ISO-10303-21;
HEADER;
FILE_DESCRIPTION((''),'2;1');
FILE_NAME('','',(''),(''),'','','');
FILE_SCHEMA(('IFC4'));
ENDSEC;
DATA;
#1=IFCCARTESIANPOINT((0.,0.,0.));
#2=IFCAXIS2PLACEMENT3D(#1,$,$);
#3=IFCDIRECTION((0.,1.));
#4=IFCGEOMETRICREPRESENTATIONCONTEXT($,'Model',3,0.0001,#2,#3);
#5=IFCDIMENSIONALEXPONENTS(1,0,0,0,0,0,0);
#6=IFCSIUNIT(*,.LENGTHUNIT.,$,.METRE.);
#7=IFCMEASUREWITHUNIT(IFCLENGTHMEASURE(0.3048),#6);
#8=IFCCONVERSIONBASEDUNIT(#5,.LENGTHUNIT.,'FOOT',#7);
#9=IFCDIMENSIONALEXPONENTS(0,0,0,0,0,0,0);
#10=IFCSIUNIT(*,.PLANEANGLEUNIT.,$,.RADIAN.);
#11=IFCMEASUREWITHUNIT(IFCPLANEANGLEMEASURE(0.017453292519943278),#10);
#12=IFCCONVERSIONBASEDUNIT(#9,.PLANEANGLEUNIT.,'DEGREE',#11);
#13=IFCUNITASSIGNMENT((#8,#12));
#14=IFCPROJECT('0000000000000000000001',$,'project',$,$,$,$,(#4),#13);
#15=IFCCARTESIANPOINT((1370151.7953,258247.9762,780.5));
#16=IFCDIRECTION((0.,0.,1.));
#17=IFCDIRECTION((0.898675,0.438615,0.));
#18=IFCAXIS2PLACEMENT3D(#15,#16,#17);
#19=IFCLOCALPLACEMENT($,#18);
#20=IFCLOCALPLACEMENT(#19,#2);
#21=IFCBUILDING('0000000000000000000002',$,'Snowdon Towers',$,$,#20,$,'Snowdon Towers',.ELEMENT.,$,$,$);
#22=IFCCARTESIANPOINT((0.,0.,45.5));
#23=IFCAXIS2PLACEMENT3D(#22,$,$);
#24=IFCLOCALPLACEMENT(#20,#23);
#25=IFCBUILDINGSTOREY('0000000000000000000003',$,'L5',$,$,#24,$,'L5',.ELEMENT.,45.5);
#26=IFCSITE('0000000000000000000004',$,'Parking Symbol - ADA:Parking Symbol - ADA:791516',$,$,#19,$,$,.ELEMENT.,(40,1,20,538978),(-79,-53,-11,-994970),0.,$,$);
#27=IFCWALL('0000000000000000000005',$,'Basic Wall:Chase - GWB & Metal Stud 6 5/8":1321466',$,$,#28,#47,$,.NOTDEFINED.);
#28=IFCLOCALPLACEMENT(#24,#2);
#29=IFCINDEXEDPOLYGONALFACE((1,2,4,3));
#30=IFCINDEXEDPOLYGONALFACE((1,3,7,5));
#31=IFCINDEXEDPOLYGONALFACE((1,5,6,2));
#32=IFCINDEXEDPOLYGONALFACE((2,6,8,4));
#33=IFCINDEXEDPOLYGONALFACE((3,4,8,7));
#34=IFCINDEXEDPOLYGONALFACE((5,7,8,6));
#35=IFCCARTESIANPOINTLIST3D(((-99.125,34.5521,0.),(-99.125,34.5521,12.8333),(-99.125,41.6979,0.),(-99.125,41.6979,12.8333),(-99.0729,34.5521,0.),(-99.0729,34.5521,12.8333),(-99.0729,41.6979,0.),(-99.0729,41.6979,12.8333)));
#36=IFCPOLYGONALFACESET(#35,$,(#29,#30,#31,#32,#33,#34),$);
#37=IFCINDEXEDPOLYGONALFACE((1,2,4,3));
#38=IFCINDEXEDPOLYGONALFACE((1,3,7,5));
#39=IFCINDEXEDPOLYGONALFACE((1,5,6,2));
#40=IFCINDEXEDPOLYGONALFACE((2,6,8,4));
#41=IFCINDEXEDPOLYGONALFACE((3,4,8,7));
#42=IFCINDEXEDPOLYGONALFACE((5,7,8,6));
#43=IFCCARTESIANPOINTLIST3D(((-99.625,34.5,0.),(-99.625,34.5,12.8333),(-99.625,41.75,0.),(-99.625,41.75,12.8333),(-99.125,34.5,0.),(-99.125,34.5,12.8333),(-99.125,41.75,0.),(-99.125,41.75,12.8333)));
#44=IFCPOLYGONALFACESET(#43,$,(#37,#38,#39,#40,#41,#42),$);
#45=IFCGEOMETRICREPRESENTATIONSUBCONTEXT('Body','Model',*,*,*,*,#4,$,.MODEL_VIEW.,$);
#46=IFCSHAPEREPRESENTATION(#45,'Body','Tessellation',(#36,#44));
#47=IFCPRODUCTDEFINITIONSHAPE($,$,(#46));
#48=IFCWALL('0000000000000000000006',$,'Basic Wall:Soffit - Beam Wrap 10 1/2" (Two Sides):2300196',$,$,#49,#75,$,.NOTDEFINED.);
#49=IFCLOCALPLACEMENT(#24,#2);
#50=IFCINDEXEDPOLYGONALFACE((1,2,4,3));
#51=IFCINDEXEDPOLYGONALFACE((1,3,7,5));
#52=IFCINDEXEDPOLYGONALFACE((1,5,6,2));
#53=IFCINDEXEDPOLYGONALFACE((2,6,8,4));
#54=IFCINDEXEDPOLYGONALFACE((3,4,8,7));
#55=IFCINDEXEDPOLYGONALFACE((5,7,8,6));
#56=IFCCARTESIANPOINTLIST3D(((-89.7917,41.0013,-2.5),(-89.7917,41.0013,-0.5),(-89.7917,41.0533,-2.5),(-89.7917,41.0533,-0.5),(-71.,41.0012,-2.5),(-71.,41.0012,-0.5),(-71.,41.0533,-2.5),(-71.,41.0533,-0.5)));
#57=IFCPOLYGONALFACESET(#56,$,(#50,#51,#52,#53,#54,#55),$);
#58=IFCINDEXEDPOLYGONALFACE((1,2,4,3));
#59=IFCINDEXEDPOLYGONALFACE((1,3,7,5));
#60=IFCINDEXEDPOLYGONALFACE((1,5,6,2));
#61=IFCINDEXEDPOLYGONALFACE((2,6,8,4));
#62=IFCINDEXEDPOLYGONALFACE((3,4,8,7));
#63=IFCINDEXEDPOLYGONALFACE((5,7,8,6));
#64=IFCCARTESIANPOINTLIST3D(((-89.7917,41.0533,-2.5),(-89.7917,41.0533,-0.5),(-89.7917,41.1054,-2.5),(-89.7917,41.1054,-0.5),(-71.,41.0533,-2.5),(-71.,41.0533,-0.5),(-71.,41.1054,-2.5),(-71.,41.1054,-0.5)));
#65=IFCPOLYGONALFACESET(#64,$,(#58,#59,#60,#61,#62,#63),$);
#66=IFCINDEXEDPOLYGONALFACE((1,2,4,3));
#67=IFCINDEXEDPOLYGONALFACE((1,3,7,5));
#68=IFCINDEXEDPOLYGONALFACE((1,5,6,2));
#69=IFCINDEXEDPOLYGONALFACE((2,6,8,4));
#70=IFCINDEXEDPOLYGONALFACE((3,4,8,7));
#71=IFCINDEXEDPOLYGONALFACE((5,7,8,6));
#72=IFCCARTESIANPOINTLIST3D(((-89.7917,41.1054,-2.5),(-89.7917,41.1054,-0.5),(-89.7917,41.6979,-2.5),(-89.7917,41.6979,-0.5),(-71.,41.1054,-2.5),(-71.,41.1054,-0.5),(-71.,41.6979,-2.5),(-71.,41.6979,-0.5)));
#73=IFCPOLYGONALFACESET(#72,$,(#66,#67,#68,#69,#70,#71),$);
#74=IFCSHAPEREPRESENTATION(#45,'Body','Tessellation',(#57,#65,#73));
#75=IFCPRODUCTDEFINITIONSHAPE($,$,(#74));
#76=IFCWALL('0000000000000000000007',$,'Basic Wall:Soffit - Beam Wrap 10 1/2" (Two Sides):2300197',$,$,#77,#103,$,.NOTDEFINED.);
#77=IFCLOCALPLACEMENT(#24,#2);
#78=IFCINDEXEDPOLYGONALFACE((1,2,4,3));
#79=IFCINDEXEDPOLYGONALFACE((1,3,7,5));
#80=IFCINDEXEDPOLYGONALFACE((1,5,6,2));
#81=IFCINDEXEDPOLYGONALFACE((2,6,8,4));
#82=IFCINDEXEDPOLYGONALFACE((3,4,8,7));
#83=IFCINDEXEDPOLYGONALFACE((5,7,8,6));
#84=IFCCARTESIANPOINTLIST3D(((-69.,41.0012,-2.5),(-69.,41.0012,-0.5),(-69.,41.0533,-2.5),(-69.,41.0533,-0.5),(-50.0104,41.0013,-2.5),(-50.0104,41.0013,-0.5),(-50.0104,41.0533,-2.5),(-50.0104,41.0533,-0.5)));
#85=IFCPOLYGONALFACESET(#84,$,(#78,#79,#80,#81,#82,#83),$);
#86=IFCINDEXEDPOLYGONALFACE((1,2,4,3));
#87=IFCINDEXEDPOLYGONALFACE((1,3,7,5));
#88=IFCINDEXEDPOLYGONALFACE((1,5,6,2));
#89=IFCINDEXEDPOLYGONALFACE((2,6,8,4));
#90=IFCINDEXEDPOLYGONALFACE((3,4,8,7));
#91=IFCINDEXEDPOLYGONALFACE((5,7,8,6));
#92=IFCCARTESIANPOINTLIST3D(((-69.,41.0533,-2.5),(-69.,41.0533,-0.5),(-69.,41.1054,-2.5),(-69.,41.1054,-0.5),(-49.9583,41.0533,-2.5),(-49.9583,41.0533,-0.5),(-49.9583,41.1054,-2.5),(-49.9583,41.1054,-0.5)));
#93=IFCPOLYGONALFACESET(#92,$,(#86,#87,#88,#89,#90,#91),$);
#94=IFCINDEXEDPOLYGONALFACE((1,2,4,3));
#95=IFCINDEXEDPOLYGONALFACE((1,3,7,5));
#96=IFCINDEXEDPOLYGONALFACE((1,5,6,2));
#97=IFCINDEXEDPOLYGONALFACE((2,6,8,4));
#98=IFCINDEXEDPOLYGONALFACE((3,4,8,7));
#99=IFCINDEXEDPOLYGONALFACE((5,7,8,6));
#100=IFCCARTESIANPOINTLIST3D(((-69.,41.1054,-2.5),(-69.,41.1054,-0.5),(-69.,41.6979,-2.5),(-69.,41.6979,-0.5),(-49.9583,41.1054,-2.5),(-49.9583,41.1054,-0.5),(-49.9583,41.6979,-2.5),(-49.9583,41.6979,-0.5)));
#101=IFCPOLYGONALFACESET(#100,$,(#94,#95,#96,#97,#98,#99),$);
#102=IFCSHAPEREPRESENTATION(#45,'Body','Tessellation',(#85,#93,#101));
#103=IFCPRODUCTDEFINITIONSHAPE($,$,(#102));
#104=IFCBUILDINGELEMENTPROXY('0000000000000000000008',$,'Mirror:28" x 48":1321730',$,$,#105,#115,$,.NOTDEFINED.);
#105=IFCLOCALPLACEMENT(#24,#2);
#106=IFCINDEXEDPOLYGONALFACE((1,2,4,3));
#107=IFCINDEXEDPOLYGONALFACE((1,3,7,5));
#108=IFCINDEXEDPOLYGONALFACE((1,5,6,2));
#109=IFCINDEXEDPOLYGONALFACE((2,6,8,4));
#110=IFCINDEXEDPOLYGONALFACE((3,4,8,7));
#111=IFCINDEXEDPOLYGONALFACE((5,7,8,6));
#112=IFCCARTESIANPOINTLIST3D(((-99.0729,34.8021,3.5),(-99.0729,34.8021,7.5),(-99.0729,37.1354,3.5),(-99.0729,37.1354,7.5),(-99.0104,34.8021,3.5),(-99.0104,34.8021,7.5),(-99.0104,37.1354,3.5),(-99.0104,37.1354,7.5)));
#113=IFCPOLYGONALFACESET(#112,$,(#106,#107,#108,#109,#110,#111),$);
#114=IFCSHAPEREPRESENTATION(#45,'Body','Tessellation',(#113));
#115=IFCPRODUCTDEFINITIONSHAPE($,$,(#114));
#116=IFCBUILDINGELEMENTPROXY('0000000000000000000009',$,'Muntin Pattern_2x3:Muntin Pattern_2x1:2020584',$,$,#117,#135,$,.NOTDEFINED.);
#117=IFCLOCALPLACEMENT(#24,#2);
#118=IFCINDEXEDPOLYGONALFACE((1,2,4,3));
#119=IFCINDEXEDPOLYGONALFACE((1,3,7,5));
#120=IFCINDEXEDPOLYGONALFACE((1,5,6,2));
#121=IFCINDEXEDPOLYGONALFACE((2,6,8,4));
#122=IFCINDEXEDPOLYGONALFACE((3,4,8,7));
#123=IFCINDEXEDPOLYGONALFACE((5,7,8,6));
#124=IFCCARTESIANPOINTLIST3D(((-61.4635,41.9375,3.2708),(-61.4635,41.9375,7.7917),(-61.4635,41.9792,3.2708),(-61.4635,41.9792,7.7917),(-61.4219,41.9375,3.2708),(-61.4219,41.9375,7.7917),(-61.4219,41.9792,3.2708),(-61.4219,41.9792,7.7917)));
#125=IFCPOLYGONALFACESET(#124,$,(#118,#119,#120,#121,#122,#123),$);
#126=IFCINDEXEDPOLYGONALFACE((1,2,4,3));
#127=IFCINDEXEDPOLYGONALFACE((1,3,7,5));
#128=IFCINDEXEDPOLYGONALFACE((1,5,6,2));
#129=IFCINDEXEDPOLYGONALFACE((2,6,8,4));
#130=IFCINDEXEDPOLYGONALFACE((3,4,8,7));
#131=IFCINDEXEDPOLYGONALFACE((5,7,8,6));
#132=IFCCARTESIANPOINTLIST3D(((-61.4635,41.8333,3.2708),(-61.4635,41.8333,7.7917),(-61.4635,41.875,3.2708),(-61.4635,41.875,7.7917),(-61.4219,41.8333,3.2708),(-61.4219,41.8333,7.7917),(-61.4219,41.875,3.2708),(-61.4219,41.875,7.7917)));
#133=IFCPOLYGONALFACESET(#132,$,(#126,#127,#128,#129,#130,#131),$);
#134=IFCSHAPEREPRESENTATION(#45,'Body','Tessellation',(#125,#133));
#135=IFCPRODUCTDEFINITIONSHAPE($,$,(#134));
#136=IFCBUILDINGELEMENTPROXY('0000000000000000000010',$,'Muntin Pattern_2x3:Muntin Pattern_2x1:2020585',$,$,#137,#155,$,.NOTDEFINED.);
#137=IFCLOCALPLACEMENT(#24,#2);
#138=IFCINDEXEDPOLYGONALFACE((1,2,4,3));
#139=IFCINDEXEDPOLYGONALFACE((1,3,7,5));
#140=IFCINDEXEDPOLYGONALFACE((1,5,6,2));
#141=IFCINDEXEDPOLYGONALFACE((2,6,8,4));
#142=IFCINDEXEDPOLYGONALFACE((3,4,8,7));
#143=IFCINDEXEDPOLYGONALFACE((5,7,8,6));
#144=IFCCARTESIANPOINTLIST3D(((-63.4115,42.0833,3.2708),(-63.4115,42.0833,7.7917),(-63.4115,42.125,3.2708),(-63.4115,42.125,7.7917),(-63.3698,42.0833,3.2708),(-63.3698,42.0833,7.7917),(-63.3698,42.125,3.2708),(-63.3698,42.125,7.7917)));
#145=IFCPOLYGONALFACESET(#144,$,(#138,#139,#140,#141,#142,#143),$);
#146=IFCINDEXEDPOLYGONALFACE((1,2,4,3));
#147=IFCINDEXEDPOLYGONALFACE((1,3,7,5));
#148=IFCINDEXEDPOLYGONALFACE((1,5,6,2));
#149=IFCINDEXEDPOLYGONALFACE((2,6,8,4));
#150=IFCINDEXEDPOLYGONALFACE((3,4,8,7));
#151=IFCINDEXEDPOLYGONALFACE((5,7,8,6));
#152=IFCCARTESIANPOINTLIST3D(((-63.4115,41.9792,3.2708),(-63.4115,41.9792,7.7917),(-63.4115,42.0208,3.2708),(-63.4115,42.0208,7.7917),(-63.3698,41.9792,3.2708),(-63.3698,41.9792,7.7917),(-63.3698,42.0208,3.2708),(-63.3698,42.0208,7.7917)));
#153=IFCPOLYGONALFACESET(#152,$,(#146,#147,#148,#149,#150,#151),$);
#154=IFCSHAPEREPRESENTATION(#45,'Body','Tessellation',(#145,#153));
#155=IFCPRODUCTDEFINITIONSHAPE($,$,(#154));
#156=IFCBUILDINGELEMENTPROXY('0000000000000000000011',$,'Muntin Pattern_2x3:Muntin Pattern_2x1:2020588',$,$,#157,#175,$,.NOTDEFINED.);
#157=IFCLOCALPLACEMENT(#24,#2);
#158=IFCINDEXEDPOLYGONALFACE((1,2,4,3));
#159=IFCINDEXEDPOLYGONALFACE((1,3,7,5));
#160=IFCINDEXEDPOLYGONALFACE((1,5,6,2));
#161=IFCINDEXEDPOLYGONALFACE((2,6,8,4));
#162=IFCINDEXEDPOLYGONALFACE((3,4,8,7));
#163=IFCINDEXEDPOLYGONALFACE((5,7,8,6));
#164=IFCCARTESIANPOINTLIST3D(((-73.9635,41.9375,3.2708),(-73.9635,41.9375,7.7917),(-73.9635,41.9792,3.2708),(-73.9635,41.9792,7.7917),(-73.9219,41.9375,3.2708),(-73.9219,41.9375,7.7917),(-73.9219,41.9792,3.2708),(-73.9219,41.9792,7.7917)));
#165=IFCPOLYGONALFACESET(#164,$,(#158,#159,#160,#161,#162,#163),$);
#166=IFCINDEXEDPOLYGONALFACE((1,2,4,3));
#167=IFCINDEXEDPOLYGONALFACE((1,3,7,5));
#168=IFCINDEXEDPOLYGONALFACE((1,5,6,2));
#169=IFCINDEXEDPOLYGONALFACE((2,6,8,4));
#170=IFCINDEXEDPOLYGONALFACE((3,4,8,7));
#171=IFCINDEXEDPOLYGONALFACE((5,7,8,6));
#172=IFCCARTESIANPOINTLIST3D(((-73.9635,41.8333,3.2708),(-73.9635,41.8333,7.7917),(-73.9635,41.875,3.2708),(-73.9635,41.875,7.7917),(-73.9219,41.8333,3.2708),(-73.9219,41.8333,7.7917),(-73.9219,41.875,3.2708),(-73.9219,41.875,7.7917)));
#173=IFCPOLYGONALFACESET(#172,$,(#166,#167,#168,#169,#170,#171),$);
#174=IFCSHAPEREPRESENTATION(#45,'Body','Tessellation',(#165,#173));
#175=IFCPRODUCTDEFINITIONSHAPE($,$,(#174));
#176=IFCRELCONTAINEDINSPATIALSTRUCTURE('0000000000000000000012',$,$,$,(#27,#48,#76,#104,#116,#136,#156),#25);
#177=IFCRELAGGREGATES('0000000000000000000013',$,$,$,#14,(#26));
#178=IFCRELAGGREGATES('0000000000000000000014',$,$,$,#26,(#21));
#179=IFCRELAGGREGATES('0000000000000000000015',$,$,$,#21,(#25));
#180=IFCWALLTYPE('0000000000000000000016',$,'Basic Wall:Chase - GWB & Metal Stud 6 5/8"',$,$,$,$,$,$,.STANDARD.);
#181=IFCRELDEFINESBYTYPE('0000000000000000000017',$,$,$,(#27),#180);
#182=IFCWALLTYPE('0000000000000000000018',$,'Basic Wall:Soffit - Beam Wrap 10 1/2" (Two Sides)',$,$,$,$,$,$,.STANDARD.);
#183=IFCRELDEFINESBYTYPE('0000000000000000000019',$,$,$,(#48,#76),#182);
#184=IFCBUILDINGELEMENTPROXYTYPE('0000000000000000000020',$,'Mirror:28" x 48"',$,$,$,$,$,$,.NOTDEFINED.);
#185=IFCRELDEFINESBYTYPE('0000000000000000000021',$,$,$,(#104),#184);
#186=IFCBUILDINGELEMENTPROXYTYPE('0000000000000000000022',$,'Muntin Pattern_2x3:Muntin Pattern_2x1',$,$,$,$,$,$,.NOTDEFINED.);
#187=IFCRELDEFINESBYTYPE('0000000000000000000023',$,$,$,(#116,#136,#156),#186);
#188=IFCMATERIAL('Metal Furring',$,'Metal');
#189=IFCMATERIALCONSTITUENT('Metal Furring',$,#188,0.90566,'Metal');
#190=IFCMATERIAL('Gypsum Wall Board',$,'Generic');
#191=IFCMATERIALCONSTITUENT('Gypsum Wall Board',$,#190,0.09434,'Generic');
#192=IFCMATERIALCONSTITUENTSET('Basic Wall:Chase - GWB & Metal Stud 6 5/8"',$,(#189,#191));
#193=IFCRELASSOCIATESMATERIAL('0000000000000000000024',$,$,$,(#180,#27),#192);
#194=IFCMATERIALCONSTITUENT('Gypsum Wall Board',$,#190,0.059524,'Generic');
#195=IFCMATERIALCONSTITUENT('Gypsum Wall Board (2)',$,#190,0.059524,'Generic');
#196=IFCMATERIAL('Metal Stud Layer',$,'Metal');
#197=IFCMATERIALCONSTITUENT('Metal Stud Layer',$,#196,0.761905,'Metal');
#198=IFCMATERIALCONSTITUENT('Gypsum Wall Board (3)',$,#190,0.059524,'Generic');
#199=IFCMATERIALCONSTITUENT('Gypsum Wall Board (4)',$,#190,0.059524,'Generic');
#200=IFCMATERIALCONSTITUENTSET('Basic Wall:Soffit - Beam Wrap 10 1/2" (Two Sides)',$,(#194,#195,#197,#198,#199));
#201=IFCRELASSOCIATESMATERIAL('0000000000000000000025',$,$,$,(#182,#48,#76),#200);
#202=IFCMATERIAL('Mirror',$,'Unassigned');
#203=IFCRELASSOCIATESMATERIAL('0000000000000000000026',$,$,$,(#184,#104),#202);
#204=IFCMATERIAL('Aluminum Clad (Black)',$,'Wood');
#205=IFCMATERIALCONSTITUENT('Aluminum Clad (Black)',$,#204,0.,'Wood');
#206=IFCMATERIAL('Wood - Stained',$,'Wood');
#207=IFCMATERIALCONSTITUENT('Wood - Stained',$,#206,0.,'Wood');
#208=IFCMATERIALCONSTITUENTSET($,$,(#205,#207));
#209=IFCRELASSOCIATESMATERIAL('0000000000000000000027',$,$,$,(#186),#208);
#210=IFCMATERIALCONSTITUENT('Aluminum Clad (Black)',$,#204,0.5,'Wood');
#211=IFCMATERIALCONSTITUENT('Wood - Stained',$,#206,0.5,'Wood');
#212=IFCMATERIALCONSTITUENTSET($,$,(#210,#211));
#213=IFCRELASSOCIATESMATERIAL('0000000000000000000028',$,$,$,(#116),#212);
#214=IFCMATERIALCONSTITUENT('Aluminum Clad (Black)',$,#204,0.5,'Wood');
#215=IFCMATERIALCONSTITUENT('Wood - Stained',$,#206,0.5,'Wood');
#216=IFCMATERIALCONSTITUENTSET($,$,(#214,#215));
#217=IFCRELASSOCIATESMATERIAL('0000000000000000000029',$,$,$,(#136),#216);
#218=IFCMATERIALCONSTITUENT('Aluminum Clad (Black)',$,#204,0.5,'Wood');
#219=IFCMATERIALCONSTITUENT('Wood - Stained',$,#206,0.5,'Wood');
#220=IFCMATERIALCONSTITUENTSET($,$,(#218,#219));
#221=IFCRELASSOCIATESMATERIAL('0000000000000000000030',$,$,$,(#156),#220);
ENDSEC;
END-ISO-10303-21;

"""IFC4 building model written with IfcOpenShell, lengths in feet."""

from ifc_helpers import new_model, entity, si_unit, converted_unit, direction, frame, origin, place, context, subcontext, project, spatial, indexed_curve, outline, extrude, source, transform, mapped, material, constituent, constituent_set, type_object, type_shapes, element, save


model = new_model("IFC4")

# Units and contexts
model_context = context("Model", 3, precision=0.0001, world=origin(), true_north=direction((0.0, 1.0)))
body_context = subcontext(model_context, "Body", "Model", "MODEL_VIEW")
ifc_project = project(units=[converted_unit("LENGTHUNIT", "FOOT", entity("IfcLengthMeasure", 0.3048), si_unit("LENGTHUNIT", "METRE"), dimensions=[1, 0, 0, 0, 0, 0, 0]), converted_unit("PLANEANGLEUNIT", "DEGREE", entity("IfcPlaneAngleMeasure", 0.017453292519943278), si_unit("PLANEANGLEUNIT", "RADIAN"), dimensions=[0, 0, 0, 0, 0, 0, 0])], contexts=[model_context])

# Site, building, storey
site_placement = place(None, frame((1370151.7953, 258247.9762, 780.5), z_axis=(0.0, 0.0, 1.0), x_axis=(0.898675, 0.438615, 0.0)))
site = spatial("IfcSite", under=ifc_project, at=site_placement, Name="Parking Symbol - ADA:Parking Symbol - ADA:791516", CompositionType="ELEMENT", RefLatitude=(40, 1, 20, 538978), RefLongitude=(-79, -53, -11, -994970), RefElevation=0.0)
building_placement = place(site_placement, origin())
building = spatial("IfcBuilding", under=site, at=building_placement, Name="Snowdon Towers", LongName="Snowdon Towers", CompositionType="ELEMENT")
storey_placement = place(building_placement, frame((0.0, 0.0, 45.5)))
storey = spatial("IfcBuildingStorey", under=building, at=storey_placement, Name="L5", LongName="L5", CompositionType="ELEMENT", Elevation=45.5)

# Wall
ifc_material_1 = material(Name="Metal Furring", Category="Metal")
ifc_material_2 = material(Name="Gypsum Wall Board", Category="Generic")
ifc_constituent_1 = constituent(ifc_material_1, Name="Metal Furring", Category="Metal", fraction=0.90566)
ifc_constituent_2 = constituent(ifc_material_2, Name="Gypsum Wall Board", Category="Generic", fraction=0.09434)
ifc_constituent_set_1 = constituent_set(constituents=[ifc_constituent_1, ifc_constituent_2], Name="Basic Wall:Chase - GWB & Metal Stud 6 5/8\"")
wall_type_1 = type_object("IfcWallType", Name="Basic Wall:Chase - GWB & Metal Stud 6 5/8\"", PredefinedType="STANDARD", material=ifc_constituent_set_1)
wall_1_placement = place(storey_placement, frame((-99.349, 41.6979, 0.0), z_axis=(0.0, 0.0, 1.0), x_axis=(0.0, -1.0, 0.0)))
element("IfcWall", 1, at=wall_1_placement, inside=storey, type_object=wall_type_1, material=ifc_constituent_set_1, Name="Basic Wall:Chase - GWB & Metal Stud 6 5/8\":1321466", PredefinedType="NOTDEFINED", context=body_context, shape_type="SweptSolid", body=[
    extrude(outline(indexed_curve([(-0.026, -3.5729), (0.026, -3.5729), (0.026, 3.5729), (-0.026, 3.5729), (-0.026, -3.5729)], self_intersect=False)), frame((3.5729, 0.25, 0.0), z_axis=(0.0, 0.0, 1.0), x_axis=(0.0, -1.0, 0.0)), (0.0, 0.0, 1.0), 12.8333),
    extrude(outline(indexed_curve([(-0.25, -3.625), (0.25, -3.625), (0.25, 3.625), (-0.25, 3.625), (-0.25, -3.625)], self_intersect=False)), frame((3.5729, -0.026, 0.0), z_axis=(0.0, 0.0, 1.0), x_axis=(0.0, -1.0, 0.0)), (0.0, 0.0, 1.0), 12.8333),
])

# Shared definitions
ifc_material_3 = material(Name="Metal Stud Layer", Category="Metal")

# Walls
ifc_constituent_3 = constituent(ifc_material_2, Name="Gypsum Wall Board", Category="Generic", fraction=0.059524)
ifc_constituent_4 = constituent(ifc_material_2, Name="Gypsum Wall Board (2)", Category="Generic", fraction=0.059524)
ifc_constituent_5 = constituent(ifc_material_3, Name="Metal Stud Layer", Category="Metal", fraction=0.761905)
ifc_constituent_6 = constituent(ifc_material_2, Name="Gypsum Wall Board (3)", Category="Generic", fraction=0.059524)
ifc_constituent_7 = constituent(ifc_material_2, Name="Gypsum Wall Board (4)", Category="Generic", fraction=0.059524)
ifc_constituent_set_2 = constituent_set(constituents=[ifc_constituent_3, ifc_constituent_4, ifc_constituent_5, ifc_constituent_6, ifc_constituent_7], Name="Basic Wall:Soffit - Beam Wrap 10 1/2\" (Two Sides)")
wall_type_2 = type_object("IfcWallType", Name="Basic Wall:Soffit - Beam Wrap 10 1/2\" (Two Sides)", PredefinedType="STANDARD", material=ifc_constituent_set_2)
wall_2_placement = place(storey_placement, frame((-89.7917, 41.4388, -2.5)))
element("IfcWall", 2, at=wall_2_placement, inside=storey, type_object=wall_type_2, material=ifc_constituent_set_2, Name="Basic Wall:Soffit - Beam Wrap 10 1/2\" (Two Sides):2300196", PredefinedType="NOTDEFINED", context=body_context, shape_type="SweptSolid", body=[
    extrude(outline(indexed_curve([(-0.026, -9.3958), (0.026, -9.3958), (0.026, 9.3958), (-0.026, 9.3958), (-0.026, -9.3958)], self_intersect=False)), frame((9.3958, -0.4115, 0.0), z_axis=(0.0, 0.0, 1.0), x_axis=(0.0, 1.0, 0.0)), (0.0, 0.0, 1.0), 2.0),
    extrude(outline(indexed_curve([(-9.3958, -0.026), (9.3958, -0.026), (9.3958, 0.026), (-9.3958, 0.026), (-9.3958, -0.026)], self_intersect=False)), frame((9.3958, -0.3594, 0.0)), (0.0, 0.0, 1.0), 2.0),
    extrude(outline(indexed_curve([(-0.2963, -9.3958), (0.2963, -9.3958), (0.2963, 9.3958), (-0.2963, 9.3958), (-0.2963, -9.3958)], self_intersect=False)), frame((9.3958, -0.0371, 0.0), z_axis=(0.0, 0.0, 1.0), x_axis=(0.0, -1.0, 0.0)), (0.0, 0.0, 1.0), 2.0),
])
wall_3_placement = place(storey_placement, frame((-69.0, 41.4388, -2.5)))
element("IfcWall", 3, at=wall_3_placement, inside=storey, type_object=wall_type_2, material=ifc_constituent_set_2, Name="Basic Wall:Soffit - Beam Wrap 10 1/2\" (Two Sides):2300197", PredefinedType="NOTDEFINED", context=body_context, shape_type="SweptSolid", body=[
    extrude(outline(indexed_curve([(-0.026, -9.4948), (0.026, -9.4948), (0.026, 9.4948), (-0.026, 9.4948), (-0.026, -9.4948)], self_intersect=False)), frame((9.4948, -0.4115, 0.0), z_axis=(0.0, 0.0, 1.0), x_axis=(0.0, 1.0, 0.0)), (0.0, 0.0, 1.0), 2.0),
    extrude(outline(indexed_curve([(-9.5208, -0.026), (9.5208, -0.026), (9.5208, 0.026), (-9.5208, 0.026), (-9.5208, -0.026)], self_intersect=False)), frame((9.5208, -0.3594, 0.0)), (0.0, 0.0, 1.0), 2.0),
    extrude(outline(indexed_curve([(-0.2963, -9.5208), (0.2963, -9.5208), (0.2963, 9.5208), (-0.2963, 9.5208), (-0.2963, -9.5208)], self_intersect=False)), frame((9.5208, -0.0371, 0.0), z_axis=(0.0, 0.0, 1.0), x_axis=(0.0, -1.0, 0.0)), (0.0, 0.0, 1.0), 2.0),
])

# Building element proxies
ifc_material_4 = material(Name="Mirror", Category="Unassigned")
building_element_proxy_type_1 = type_object("IfcBuildingElementProxyType", Name="Mirror:28\" x 48\"", PredefinedType="NOTDEFINED", material=ifc_material_4)
shared_shape_1 = source(origin(), body_context, "Body", "SweptSolid", [
    extrude(outline(indexed_curve([(-1.1667, -0.0312), (1.1667, -0.0312), (1.1667, 0.0312), (-1.1667, 0.0312), (-1.1667, -0.0312)], self_intersect=False)), frame((0.0803, -0.3073, 3.5)), (0.0, 0.0, 1.0), 4.0),
])
type_shapes(building_element_proxy_type_1, [shared_shape_1])
proxy_1_placement = place(storey_placement, frame((-99.349, 35.8885, 0.0), z_axis=(0.0, 0.0, 1.0), x_axis=(0.0, 1.0, 0.0)))
element("IfcBuildingElementProxy", 4, at=proxy_1_placement, inside=storey, type_object=building_element_proxy_type_1, material=ifc_material_4, Name="Mirror:28\" x 48\":1321730", PredefinedType="NOTDEFINED", context=body_context, shape_type="MappedRepresentation", body=[
    mapped(shared_shape_1, transform((0.0, 0.0, 0.0), scale=1.0)),
])
ifc_material_5 = material(Name="Aluminum Clad (Black)", Category="Wood")
ifc_constituent_8 = constituent(ifc_material_5, Name="Aluminum Clad (Black)", Category="Wood", fraction=0.5)
ifc_material_6 = material(Name="Wood - Stained", Category="Wood")
ifc_constituent_9 = constituent(ifc_material_6, Name="Wood - Stained", Category="Wood", fraction=0.5)
ifc_constituent_set_3 = constituent_set(constituents=[ifc_constituent_8, ifc_constituent_9])
ifc_constituent_10 = constituent(ifc_material_5, Name="Aluminum Clad (Black)", Category="Wood", fraction=0.0)
ifc_constituent_11 = constituent(ifc_material_6, Name="Wood - Stained", Category="Wood", fraction=0.0)
ifc_constituent_set_4 = constituent_set(constituents=[ifc_constituent_10, ifc_constituent_11])
building_element_proxy_type_2 = type_object("IfcBuildingElementProxyType", Name="Muntin Pattern_2x3:Muntin Pattern_2x1", PredefinedType="NOTDEFINED", material=ifc_constituent_set_4)
shared_shape_2 = source(origin(), body_context, "Body", "SweptSolid", [
    extrude(outline(indexed_curve([(-0.0208, -0.0208), (0.0208, -0.0208), (0.0208, 0.0208), (-0.0208, 0.0208), (-0.0208, -0.0208)], self_intersect=False)), frame((0.0, 0.0521, 0.0), z_axis=(0.0, 0.0, 1.0), x_axis=(0.0, -1.0, 0.0)), (0.0, 0.0, 1.0), 4.5208),
    extrude(outline(indexed_curve([(-0.0208, -0.0208), (0.0208, -0.0208), (0.0208, 0.0208), (-0.0208, 0.0208), (-0.0208, -0.0208)], self_intersect=False)), frame((0.0, -0.0521, 0.0), z_axis=(0.0, 0.0, 1.0), x_axis=(0.0, -1.0, 0.0)), (0.0, 0.0, 1.0), 4.5208),
])
type_shapes(building_element_proxy_type_2, [shared_shape_2])
proxy_2_placement = place(storey_placement, frame((-61.4427, 41.9063, 3.2708)))
element("IfcBuildingElementProxy", 5, at=proxy_2_placement, inside=storey, type_object=building_element_proxy_type_2, material=ifc_constituent_set_3, Name="Muntin Pattern_2x3:Muntin Pattern_2x1:2020584", PredefinedType="NOTDEFINED", context=body_context, shape_type="MappedRepresentation", body=[
    mapped(shared_shape_2, transform((0.0, 0.0, 0.0), scale=1.0)),
])
ifc_constituent_12 = constituent(ifc_material_5, Name="Aluminum Clad (Black)", Category="Wood", fraction=0.5)
ifc_constituent_13 = constituent(ifc_material_6, Name="Wood - Stained", Category="Wood", fraction=0.5)
ifc_constituent_set_5 = constituent_set(constituents=[ifc_constituent_12, ifc_constituent_13])
proxy_3_placement = place(storey_placement, frame((-63.3906, 42.0521, 3.2708)))
element("IfcBuildingElementProxy", 6, at=proxy_3_placement, inside=storey, type_object=building_element_proxy_type_2, material=ifc_constituent_set_5, Name="Muntin Pattern_2x3:Muntin Pattern_2x1:2020585", PredefinedType="NOTDEFINED", context=body_context, shape_type="MappedRepresentation", body=[
    mapped(shared_shape_2, transform((0.0, 0.0, 0.0), scale=1.0)),
])
ifc_constituent_14 = constituent(ifc_material_5, Name="Aluminum Clad (Black)", Category="Wood", fraction=0.5)
ifc_constituent_15 = constituent(ifc_material_6, Name="Wood - Stained", Category="Wood", fraction=0.5)
ifc_constituent_set_6 = constituent_set(constituents=[ifc_constituent_14, ifc_constituent_15])
proxy_4_placement = place(storey_placement, frame((-73.9427, 41.9063, 3.2708)))
element("IfcBuildingElementProxy", 7, at=proxy_4_placement, inside=storey, type_object=building_element_proxy_type_2, material=ifc_constituent_set_6, Name="Muntin Pattern_2x3:Muntin Pattern_2x1:2020588", PredefinedType="NOTDEFINED", context=body_context, shape_type="MappedRepresentation", body=[
    mapped(shared_shape_2, transform((0.0, 0.0, 0.0), scale=1.0)),
])

save(model, "model.ifc")
